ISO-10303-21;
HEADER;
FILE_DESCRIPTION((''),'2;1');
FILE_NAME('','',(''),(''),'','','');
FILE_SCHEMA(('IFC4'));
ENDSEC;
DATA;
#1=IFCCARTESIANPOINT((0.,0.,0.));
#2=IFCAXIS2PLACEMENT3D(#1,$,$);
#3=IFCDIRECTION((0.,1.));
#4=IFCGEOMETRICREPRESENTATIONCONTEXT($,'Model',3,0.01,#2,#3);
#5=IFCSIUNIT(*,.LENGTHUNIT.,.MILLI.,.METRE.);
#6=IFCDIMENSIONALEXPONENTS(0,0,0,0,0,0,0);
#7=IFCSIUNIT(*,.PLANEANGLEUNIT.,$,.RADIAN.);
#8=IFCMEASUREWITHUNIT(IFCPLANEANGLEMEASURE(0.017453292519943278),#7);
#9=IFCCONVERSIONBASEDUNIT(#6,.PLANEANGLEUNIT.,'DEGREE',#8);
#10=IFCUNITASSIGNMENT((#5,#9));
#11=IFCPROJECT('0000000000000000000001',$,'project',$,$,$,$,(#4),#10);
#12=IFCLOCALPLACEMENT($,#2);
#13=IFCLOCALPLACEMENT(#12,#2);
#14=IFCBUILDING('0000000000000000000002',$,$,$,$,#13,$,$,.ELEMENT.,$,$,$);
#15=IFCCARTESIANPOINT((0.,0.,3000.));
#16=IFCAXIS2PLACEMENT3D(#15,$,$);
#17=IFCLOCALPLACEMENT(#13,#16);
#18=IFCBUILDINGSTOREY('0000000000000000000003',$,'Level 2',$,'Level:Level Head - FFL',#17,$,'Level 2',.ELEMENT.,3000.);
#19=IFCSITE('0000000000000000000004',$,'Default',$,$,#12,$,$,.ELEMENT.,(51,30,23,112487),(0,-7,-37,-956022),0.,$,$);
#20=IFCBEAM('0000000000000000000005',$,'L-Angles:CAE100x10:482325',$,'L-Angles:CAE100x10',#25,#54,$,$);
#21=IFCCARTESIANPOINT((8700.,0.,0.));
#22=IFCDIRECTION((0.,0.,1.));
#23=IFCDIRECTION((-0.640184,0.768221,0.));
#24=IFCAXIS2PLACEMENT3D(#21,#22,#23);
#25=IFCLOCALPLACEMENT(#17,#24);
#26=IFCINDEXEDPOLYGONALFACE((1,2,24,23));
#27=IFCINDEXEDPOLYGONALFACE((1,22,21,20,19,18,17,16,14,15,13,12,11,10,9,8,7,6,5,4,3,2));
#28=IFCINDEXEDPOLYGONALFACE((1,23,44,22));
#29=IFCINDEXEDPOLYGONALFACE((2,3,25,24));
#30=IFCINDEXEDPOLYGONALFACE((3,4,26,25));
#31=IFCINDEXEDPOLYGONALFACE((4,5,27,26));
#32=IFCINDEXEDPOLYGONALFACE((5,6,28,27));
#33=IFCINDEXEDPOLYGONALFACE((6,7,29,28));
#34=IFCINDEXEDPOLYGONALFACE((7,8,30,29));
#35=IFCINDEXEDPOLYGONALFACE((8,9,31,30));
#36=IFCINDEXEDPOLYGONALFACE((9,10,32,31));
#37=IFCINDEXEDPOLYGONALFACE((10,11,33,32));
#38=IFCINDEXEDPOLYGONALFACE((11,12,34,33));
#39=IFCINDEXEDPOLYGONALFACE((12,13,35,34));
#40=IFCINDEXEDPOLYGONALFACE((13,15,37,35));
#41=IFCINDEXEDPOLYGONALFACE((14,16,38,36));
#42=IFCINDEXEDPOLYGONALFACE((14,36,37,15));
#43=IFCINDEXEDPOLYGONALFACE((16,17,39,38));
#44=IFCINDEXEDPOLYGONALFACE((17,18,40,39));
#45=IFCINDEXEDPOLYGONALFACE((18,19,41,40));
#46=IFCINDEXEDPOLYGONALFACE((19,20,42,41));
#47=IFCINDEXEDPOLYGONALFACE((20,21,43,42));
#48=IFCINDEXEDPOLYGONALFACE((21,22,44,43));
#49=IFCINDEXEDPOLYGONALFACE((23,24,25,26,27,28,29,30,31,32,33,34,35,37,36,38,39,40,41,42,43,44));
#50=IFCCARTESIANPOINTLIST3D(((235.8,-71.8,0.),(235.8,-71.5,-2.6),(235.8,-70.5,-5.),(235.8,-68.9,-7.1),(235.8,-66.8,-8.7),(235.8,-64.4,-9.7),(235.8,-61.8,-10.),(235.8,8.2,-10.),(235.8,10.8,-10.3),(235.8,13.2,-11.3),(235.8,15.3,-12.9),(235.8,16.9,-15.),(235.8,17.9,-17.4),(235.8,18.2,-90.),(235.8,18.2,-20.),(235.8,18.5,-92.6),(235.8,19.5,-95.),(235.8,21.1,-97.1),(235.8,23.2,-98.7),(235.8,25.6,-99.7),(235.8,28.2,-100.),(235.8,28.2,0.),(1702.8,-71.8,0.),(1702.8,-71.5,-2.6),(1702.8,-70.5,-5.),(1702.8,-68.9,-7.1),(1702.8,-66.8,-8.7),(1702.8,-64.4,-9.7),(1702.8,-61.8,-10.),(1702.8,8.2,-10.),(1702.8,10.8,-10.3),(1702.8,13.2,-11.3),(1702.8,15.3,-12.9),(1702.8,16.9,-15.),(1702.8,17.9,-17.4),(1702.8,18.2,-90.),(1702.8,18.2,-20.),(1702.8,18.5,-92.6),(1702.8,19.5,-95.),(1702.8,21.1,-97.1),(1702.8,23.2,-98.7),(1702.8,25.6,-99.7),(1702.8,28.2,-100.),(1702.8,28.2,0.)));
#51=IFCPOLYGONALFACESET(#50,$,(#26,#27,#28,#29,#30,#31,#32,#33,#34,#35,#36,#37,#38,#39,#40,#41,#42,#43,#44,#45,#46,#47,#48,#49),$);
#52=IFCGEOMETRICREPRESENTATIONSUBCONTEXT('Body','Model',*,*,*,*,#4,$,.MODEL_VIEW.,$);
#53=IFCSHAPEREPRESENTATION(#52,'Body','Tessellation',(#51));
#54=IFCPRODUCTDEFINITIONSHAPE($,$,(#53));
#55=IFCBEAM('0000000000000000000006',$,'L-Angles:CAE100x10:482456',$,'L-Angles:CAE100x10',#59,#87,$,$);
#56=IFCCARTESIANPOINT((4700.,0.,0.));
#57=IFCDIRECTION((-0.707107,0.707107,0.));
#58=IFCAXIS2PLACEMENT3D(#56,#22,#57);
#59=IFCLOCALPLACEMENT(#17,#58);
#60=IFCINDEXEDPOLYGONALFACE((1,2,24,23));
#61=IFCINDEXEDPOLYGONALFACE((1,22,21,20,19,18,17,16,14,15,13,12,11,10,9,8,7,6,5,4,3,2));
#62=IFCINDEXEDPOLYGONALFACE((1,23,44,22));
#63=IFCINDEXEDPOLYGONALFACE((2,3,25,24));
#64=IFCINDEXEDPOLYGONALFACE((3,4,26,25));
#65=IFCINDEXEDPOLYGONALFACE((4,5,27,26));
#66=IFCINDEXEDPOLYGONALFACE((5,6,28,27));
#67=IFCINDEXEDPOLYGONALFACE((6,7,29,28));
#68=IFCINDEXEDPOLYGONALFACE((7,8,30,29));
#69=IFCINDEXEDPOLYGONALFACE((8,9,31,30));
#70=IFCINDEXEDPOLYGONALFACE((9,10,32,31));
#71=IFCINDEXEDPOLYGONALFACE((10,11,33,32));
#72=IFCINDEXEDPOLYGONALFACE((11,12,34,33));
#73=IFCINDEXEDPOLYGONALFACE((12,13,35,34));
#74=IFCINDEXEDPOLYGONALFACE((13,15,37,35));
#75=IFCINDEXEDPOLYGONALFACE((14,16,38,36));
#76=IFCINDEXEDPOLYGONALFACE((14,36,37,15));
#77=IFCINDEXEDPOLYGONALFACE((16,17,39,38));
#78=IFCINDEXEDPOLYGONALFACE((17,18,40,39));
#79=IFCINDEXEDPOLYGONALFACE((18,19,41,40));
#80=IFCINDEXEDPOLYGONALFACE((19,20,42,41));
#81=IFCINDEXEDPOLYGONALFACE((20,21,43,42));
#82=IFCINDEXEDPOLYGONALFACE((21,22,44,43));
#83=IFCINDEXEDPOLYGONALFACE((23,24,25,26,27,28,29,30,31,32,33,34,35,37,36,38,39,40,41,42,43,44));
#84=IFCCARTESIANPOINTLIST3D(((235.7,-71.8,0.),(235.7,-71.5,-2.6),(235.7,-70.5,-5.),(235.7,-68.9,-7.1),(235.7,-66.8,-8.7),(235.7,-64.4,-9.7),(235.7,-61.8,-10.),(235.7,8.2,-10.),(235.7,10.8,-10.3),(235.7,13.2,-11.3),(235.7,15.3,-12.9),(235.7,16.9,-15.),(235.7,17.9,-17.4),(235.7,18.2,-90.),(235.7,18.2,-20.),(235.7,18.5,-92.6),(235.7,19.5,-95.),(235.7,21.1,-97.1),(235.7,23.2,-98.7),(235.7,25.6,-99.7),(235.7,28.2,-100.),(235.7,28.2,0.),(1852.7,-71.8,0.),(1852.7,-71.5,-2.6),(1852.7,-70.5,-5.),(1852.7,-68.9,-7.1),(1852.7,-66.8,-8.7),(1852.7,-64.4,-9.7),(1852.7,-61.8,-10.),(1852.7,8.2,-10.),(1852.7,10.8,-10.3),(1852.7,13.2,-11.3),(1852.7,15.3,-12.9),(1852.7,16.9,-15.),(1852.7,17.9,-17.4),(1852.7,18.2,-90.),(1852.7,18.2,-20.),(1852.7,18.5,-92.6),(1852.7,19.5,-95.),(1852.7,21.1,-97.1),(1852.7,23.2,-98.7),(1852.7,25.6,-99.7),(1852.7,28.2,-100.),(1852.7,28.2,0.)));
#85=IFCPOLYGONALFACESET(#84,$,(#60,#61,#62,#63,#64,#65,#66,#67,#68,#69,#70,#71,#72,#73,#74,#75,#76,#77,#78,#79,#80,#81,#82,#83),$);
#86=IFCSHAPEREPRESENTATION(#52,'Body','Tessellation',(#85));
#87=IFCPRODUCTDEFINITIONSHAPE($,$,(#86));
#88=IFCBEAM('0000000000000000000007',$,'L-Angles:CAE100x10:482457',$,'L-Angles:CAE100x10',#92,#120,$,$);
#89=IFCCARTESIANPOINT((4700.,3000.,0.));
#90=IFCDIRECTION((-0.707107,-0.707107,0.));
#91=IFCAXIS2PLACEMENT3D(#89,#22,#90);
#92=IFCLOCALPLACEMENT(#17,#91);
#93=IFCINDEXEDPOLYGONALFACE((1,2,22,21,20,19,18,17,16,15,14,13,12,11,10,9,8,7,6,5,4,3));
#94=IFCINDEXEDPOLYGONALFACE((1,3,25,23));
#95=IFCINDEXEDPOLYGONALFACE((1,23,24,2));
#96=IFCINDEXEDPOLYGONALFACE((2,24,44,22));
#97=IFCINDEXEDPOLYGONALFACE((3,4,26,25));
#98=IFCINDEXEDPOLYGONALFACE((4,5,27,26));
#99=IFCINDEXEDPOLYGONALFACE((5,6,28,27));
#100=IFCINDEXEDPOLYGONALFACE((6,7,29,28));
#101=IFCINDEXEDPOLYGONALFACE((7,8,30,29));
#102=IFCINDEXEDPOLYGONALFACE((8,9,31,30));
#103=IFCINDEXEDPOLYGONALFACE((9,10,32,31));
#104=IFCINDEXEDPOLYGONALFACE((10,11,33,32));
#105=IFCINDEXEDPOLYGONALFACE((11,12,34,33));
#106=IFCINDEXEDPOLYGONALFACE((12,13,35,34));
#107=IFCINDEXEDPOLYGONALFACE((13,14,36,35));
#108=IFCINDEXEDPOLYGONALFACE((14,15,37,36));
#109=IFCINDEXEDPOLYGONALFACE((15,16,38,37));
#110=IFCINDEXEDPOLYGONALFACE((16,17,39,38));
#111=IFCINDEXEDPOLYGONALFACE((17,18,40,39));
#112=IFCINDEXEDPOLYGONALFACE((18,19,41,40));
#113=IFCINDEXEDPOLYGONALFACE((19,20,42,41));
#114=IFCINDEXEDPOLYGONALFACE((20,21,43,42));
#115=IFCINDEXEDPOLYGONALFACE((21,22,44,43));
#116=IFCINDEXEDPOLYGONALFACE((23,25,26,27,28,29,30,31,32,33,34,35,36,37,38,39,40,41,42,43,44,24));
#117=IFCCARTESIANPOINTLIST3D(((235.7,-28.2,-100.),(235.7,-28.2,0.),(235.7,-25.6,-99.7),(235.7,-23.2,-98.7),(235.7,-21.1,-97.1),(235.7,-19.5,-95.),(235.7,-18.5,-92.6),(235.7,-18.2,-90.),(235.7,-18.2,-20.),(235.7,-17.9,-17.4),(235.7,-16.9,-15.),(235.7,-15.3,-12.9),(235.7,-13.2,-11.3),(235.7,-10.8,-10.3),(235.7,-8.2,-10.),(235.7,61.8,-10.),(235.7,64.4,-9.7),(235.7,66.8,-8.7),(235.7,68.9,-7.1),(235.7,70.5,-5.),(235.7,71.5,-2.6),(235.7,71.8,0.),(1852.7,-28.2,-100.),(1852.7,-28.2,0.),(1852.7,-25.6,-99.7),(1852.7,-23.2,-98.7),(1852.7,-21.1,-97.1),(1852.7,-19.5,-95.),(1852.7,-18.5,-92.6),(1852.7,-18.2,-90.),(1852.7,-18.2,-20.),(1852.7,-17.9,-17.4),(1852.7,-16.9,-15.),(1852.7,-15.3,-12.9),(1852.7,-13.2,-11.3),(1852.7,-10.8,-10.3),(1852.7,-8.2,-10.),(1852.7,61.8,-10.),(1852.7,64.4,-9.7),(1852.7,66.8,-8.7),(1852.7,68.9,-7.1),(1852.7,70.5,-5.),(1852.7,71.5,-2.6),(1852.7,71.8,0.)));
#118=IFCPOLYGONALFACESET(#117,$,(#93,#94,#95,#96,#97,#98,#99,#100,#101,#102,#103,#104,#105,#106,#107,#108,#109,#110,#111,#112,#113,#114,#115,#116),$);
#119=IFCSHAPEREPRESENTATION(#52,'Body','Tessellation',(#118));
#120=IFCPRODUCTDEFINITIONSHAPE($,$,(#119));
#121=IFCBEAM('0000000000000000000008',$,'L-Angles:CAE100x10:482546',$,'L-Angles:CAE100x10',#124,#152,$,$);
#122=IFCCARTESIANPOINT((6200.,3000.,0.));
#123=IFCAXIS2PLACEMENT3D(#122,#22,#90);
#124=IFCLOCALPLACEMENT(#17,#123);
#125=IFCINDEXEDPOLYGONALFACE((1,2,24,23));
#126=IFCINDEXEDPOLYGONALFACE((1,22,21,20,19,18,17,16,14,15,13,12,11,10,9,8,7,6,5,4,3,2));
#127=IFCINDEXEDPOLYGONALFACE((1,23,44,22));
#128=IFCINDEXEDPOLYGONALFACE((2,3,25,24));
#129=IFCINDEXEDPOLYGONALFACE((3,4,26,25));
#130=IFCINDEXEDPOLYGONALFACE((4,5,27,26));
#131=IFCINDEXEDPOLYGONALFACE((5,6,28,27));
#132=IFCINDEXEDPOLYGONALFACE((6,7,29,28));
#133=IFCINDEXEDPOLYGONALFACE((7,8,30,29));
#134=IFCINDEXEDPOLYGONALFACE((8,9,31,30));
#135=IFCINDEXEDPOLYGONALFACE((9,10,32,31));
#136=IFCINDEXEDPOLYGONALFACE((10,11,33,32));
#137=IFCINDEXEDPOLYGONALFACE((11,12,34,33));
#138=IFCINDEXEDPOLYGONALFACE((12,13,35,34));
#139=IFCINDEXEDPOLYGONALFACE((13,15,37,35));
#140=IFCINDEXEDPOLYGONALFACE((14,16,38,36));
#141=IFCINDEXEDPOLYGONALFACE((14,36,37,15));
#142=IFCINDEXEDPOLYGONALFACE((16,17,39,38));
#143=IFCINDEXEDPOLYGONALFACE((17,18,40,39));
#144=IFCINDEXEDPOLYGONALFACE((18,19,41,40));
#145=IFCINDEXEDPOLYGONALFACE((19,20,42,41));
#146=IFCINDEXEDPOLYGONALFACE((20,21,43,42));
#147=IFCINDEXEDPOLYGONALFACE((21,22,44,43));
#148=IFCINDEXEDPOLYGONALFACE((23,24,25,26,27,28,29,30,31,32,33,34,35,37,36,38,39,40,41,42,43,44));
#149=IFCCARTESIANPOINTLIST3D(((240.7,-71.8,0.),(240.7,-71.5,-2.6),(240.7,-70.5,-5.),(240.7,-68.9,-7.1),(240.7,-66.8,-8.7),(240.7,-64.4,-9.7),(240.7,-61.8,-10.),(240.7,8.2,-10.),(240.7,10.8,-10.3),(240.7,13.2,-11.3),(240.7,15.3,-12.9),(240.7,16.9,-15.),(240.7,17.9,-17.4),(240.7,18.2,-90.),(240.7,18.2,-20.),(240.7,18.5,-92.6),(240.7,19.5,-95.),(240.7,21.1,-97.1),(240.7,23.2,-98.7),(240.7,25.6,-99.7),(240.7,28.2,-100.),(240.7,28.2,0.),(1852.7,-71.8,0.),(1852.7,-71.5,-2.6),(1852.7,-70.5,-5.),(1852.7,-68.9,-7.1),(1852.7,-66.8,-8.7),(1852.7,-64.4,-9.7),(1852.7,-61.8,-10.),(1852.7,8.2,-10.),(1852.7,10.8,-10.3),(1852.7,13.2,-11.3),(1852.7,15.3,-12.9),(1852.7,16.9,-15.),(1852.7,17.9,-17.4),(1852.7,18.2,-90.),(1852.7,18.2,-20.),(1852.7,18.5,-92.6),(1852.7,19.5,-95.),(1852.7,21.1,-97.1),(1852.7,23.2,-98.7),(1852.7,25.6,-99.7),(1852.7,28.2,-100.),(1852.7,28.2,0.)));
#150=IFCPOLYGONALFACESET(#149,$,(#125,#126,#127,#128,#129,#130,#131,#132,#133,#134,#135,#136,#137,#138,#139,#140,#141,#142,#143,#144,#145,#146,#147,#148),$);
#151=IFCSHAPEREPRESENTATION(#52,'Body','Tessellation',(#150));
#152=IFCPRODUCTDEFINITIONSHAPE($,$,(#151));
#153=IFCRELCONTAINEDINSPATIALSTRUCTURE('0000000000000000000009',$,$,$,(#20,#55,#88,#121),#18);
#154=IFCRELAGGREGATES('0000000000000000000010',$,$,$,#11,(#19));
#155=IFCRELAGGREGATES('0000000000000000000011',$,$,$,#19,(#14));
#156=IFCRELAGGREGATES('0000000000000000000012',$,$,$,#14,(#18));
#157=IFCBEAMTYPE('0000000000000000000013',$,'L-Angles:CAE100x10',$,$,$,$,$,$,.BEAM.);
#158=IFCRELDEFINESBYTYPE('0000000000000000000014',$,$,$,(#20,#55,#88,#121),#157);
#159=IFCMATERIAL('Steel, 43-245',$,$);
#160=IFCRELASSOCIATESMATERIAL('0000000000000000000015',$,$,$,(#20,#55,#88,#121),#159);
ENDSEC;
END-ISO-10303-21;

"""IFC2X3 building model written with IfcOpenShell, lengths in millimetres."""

from ifc_helpers import new_model, entity, si_unit, converted_unit, direction, frame, frame_2d, origin, place, context, subcontext, project, spatial, polyline, circle_curve, parameter, trimmed, segment, composite_curve, outline, extrude, material, type_object, element, save


model = new_model("IFC2X3")

# Units and contexts
model_context = context("Model", 3, precision=0.01, world=origin(), true_north=direction((0.0, 1.0)))
body_context = subcontext(model_context, "Body", "Model", "MODEL_VIEW")
ifc_project = project(units=[si_unit("LENGTHUNIT", "METRE", prefix="MILLI"), converted_unit("PLANEANGLEUNIT", "DEGREE", entity("IfcPlaneAngleMeasure", 0.017453292519943278), si_unit("PLANEANGLEUNIT", "RADIAN"), dimensions=[0, 0, 0, 0, 0, 0, 0])], contexts=[model_context])

# Site, building, storey
site_placement = place(None, origin())
site = spatial("IfcSite", under=ifc_project, at=site_placement, Name="Default", CompositionType="ELEMENT", RefLatitude=(51, 30, 23, 112487), RefLongitude=(0, -7, -37, -956022), RefElevation=0.0)
building_placement = place(site_placement, origin())
building = spatial("IfcBuilding", under=site, at=building_placement, CompositionType="ELEMENT")
storey_placement = place(building_placement, frame((0.0, 0.0, 3000.0)))
storey = spatial("IfcBuildingStorey", under=building, at=storey_placement, Name="Level 2", ObjectType="Level:Level Head - FFL", LongName="Level 2", CompositionType="ELEMENT", Elevation=3000.0)

# Beams
ifc_material = material(Name="Steel, 43-245")
beam_type_1 = type_object("IfcBeamType", Name="L-Angles:CAE100x10", PredefinedType="BEAM")
beam_1_placement = place(storey_placement, frame((8700.0, 0.0, 0.0), z_axis=(0.0, 0.0, 1.0), x_axis=(-0.640184, 0.768221, 0.0)))
element("IfcBeam", 1, at=beam_1_placement, inside=storey, type_object=beam_type_1, material=ifc_material, Name="L-Angles:CAE100x10:482325", ObjectType="L-Angles:CAE100x10", context=body_context, shape_type="SweptSolid", body=[
    extrude(outline(composite_curve([segment(polyline([(-67.1, -32.9), (32.9, -32.9)]), True, "CONTINUOUS"), segment(polyline([(32.9, -32.9), (32.9, 67.1)]), True, "CONTINUOUS"), segment(trimmed(circle_curve(frame_2d((32.9, 57.1), x_axis=(0.0, 1.0)), 10.0), [parameter(0.0)], [parameter(90.0)], True, "PARAMETER"), True, "CONTINUOUS"), segment(polyline([(22.9, 57.1), (22.9, -12.9)]), True, "CONTINUOUS"), segment(trimmed(circle_curve(frame_2d((12.9, -12.9), x_axis=(1.0, 0.0)), 10.0), [parameter(270.0)], [parameter(0.0)], True, "PARAMETER"), False, "CONTINUOUS"), segment(polyline([(12.9, -22.9), (-57.1, -22.9)]), True, "CONTINUOUS"), segment(trimmed(circle_curve(frame_2d((-57.1, -32.9), x_axis=(0.0, 1.0)), 10.0), [parameter(0.0)], [parameter(90.0)], True, "PARAMETER"), True, "CONTINUOUS")], self_intersect=False)), frame((235.8, -4.7, -32.9), z_axis=(1.0, 0.0, 0.0), x_axis=(0.0, 0.0, 1.0)), (0.0, 0.0, 1.0), 1467.0),
])
beam_2_placement = place(storey_placement, frame((4700.0, 0.0, 0.0), z_axis=(0.0, 0.0, 1.0), x_axis=(-0.707107, 0.707107, 0.0)))
element("IfcBeam", 2, at=beam_2_placement, inside=storey, type_object=beam_type_1, material=ifc_material, Name="L-Angles:CAE100x10:482456", ObjectType="L-Angles:CAE100x10", context=body_context, shape_type="SweptSolid", body=[
    extrude(outline(composite_curve([segment(polyline([(-67.1, -32.9), (32.9, -32.9)]), True, "CONTINUOUS"), segment(polyline([(32.9, -32.9), (32.9, 67.1)]), True, "CONTINUOUS"), segment(trimmed(circle_curve(frame_2d((32.9, 57.1), x_axis=(0.0, 1.0)), 10.0), [parameter(0.0)], [parameter(90.0)], True, "PARAMETER"), True, "CONTINUOUS"), segment(polyline([(22.9, 57.1), (22.9, -12.9)]), True, "CONTINUOUS"), segment(trimmed(circle_curve(frame_2d((12.9, -12.9), x_axis=(1.0, 0.0)), 10.0), [parameter(270.0)], [parameter(0.0)], True, "PARAMETER"), False, "CONTINUOUS"), segment(polyline([(12.9, -22.9), (-57.1, -22.9)]), True, "CONTINUOUS"), segment(trimmed(circle_curve(frame_2d((-57.1, -32.9), x_axis=(0.0, 1.0)), 10.0), [parameter(0.0)], [parameter(90.0)], True, "PARAMETER"), True, "CONTINUOUS")], self_intersect=False)), frame((235.7, -4.7, -32.9), z_axis=(1.0, 0.0, 0.0), x_axis=(0.0, 0.0, 1.0)), (0.0, 0.0, 1.0), 1617.0),
])
beam_3_placement = place(storey_placement, frame((4700.0, 3000.0, 0.0), z_axis=(0.0, 0.0, 1.0), x_axis=(-0.707107, -0.707107, 0.0)))
element("IfcBeam", 3, at=beam_3_placement, inside=storey, type_object=beam_type_1, material=ifc_material, Name="L-Angles:CAE100x10:482457", ObjectType="L-Angles:CAE100x10", context=body_context, shape_type="SweptSolid", body=[
    extrude(outline(composite_curve([segment(polyline([(-32.9, -32.9), (67.1, -32.9)]), True, "CONTINUOUS"), segment(trimmed(circle_curve(frame_2d((57.1, -32.9), x_axis=(1.0, 0.0)), 10.0), [parameter(0.0)], [parameter(90.0)], True, "PARAMETER"), True, "CONTINUOUS"), segment(polyline([(57.1, -22.9), (-12.9, -22.9)]), True, "CONTINUOUS"), segment(trimmed(circle_curve(frame_2d((-12.9, -12.9), x_axis=(0.0, -1.0)), 10.0), [parameter(270.0)], [parameter(0.0)], True, "PARAMETER"), False, "CONTINUOUS"), segment(polyline([(-22.9, -12.9), (-22.9, 57.1)]), True, "CONTINUOUS"), segment(trimmed(circle_curve(frame_2d((-32.9, 57.1), x_axis=(1.0, 0.0)), 10.0), [parameter(0.0)], [parameter(90.0)], True, "PARAMETER"), True, "CONTINUOUS"), segment(polyline([(-32.9, 67.1), (-32.9, -32.9)]), True, "CONTINUOUS")], self_intersect=False)), frame((235.7, 4.7, -32.9), z_axis=(1.0, 0.0, 0.0), x_axis=(0.0, 0.0, -1.0)), (0.0, 0.0, 1.0), 1617.0),
])
beam_4_placement = place(storey_placement, frame((6200.0, 3000.0, 0.0), z_axis=(0.0, 0.0, 1.0), x_axis=(-0.707107, -0.707107, 0.0)))
element("IfcBeam", 4, at=beam_4_placement, inside=storey, type_object=beam_type_1, material=ifc_material, Name="L-Angles:CAE100x10:482546", ObjectType="L-Angles:CAE100x10", context=body_context, shape_type="SweptSolid", body=[
    extrude(outline(composite_curve([segment(polyline([(-67.1, -32.9), (32.9, -32.9)]), True, "CONTINUOUS"), segment(polyline([(32.9, -32.9), (32.9, 67.1)]), True, "CONTINUOUS"), segment(trimmed(circle_curve(frame_2d((32.9, 57.1), x_axis=(0.0, 1.0)), 10.0), [parameter(0.0)], [parameter(90.0)], True, "PARAMETER"), True, "CONTINUOUS"), segment(polyline([(22.9, 57.1), (22.9, -12.9)]), True, "CONTINUOUS"), segment(trimmed(circle_curve(frame_2d((12.9, -12.9), x_axis=(1.0, 0.0)), 10.0), [parameter(270.0)], [parameter(0.0)], True, "PARAMETER"), False, "CONTINUOUS"), segment(polyline([(12.9, -22.9), (-57.1, -22.9)]), True, "CONTINUOUS"), segment(trimmed(circle_curve(frame_2d((-57.1, -32.9), x_axis=(0.0, 1.0)), 10.0), [parameter(0.0)], [parameter(90.0)], True, "PARAMETER"), True, "CONTINUOUS")], self_intersect=False)), frame((240.7, -4.7, -32.9), z_axis=(1.0, 0.0, 0.0), x_axis=(0.0, 0.0, 1.0)), (0.0, 0.0, 1.0), 1612.0),
])

save(model, "model.ifc")
